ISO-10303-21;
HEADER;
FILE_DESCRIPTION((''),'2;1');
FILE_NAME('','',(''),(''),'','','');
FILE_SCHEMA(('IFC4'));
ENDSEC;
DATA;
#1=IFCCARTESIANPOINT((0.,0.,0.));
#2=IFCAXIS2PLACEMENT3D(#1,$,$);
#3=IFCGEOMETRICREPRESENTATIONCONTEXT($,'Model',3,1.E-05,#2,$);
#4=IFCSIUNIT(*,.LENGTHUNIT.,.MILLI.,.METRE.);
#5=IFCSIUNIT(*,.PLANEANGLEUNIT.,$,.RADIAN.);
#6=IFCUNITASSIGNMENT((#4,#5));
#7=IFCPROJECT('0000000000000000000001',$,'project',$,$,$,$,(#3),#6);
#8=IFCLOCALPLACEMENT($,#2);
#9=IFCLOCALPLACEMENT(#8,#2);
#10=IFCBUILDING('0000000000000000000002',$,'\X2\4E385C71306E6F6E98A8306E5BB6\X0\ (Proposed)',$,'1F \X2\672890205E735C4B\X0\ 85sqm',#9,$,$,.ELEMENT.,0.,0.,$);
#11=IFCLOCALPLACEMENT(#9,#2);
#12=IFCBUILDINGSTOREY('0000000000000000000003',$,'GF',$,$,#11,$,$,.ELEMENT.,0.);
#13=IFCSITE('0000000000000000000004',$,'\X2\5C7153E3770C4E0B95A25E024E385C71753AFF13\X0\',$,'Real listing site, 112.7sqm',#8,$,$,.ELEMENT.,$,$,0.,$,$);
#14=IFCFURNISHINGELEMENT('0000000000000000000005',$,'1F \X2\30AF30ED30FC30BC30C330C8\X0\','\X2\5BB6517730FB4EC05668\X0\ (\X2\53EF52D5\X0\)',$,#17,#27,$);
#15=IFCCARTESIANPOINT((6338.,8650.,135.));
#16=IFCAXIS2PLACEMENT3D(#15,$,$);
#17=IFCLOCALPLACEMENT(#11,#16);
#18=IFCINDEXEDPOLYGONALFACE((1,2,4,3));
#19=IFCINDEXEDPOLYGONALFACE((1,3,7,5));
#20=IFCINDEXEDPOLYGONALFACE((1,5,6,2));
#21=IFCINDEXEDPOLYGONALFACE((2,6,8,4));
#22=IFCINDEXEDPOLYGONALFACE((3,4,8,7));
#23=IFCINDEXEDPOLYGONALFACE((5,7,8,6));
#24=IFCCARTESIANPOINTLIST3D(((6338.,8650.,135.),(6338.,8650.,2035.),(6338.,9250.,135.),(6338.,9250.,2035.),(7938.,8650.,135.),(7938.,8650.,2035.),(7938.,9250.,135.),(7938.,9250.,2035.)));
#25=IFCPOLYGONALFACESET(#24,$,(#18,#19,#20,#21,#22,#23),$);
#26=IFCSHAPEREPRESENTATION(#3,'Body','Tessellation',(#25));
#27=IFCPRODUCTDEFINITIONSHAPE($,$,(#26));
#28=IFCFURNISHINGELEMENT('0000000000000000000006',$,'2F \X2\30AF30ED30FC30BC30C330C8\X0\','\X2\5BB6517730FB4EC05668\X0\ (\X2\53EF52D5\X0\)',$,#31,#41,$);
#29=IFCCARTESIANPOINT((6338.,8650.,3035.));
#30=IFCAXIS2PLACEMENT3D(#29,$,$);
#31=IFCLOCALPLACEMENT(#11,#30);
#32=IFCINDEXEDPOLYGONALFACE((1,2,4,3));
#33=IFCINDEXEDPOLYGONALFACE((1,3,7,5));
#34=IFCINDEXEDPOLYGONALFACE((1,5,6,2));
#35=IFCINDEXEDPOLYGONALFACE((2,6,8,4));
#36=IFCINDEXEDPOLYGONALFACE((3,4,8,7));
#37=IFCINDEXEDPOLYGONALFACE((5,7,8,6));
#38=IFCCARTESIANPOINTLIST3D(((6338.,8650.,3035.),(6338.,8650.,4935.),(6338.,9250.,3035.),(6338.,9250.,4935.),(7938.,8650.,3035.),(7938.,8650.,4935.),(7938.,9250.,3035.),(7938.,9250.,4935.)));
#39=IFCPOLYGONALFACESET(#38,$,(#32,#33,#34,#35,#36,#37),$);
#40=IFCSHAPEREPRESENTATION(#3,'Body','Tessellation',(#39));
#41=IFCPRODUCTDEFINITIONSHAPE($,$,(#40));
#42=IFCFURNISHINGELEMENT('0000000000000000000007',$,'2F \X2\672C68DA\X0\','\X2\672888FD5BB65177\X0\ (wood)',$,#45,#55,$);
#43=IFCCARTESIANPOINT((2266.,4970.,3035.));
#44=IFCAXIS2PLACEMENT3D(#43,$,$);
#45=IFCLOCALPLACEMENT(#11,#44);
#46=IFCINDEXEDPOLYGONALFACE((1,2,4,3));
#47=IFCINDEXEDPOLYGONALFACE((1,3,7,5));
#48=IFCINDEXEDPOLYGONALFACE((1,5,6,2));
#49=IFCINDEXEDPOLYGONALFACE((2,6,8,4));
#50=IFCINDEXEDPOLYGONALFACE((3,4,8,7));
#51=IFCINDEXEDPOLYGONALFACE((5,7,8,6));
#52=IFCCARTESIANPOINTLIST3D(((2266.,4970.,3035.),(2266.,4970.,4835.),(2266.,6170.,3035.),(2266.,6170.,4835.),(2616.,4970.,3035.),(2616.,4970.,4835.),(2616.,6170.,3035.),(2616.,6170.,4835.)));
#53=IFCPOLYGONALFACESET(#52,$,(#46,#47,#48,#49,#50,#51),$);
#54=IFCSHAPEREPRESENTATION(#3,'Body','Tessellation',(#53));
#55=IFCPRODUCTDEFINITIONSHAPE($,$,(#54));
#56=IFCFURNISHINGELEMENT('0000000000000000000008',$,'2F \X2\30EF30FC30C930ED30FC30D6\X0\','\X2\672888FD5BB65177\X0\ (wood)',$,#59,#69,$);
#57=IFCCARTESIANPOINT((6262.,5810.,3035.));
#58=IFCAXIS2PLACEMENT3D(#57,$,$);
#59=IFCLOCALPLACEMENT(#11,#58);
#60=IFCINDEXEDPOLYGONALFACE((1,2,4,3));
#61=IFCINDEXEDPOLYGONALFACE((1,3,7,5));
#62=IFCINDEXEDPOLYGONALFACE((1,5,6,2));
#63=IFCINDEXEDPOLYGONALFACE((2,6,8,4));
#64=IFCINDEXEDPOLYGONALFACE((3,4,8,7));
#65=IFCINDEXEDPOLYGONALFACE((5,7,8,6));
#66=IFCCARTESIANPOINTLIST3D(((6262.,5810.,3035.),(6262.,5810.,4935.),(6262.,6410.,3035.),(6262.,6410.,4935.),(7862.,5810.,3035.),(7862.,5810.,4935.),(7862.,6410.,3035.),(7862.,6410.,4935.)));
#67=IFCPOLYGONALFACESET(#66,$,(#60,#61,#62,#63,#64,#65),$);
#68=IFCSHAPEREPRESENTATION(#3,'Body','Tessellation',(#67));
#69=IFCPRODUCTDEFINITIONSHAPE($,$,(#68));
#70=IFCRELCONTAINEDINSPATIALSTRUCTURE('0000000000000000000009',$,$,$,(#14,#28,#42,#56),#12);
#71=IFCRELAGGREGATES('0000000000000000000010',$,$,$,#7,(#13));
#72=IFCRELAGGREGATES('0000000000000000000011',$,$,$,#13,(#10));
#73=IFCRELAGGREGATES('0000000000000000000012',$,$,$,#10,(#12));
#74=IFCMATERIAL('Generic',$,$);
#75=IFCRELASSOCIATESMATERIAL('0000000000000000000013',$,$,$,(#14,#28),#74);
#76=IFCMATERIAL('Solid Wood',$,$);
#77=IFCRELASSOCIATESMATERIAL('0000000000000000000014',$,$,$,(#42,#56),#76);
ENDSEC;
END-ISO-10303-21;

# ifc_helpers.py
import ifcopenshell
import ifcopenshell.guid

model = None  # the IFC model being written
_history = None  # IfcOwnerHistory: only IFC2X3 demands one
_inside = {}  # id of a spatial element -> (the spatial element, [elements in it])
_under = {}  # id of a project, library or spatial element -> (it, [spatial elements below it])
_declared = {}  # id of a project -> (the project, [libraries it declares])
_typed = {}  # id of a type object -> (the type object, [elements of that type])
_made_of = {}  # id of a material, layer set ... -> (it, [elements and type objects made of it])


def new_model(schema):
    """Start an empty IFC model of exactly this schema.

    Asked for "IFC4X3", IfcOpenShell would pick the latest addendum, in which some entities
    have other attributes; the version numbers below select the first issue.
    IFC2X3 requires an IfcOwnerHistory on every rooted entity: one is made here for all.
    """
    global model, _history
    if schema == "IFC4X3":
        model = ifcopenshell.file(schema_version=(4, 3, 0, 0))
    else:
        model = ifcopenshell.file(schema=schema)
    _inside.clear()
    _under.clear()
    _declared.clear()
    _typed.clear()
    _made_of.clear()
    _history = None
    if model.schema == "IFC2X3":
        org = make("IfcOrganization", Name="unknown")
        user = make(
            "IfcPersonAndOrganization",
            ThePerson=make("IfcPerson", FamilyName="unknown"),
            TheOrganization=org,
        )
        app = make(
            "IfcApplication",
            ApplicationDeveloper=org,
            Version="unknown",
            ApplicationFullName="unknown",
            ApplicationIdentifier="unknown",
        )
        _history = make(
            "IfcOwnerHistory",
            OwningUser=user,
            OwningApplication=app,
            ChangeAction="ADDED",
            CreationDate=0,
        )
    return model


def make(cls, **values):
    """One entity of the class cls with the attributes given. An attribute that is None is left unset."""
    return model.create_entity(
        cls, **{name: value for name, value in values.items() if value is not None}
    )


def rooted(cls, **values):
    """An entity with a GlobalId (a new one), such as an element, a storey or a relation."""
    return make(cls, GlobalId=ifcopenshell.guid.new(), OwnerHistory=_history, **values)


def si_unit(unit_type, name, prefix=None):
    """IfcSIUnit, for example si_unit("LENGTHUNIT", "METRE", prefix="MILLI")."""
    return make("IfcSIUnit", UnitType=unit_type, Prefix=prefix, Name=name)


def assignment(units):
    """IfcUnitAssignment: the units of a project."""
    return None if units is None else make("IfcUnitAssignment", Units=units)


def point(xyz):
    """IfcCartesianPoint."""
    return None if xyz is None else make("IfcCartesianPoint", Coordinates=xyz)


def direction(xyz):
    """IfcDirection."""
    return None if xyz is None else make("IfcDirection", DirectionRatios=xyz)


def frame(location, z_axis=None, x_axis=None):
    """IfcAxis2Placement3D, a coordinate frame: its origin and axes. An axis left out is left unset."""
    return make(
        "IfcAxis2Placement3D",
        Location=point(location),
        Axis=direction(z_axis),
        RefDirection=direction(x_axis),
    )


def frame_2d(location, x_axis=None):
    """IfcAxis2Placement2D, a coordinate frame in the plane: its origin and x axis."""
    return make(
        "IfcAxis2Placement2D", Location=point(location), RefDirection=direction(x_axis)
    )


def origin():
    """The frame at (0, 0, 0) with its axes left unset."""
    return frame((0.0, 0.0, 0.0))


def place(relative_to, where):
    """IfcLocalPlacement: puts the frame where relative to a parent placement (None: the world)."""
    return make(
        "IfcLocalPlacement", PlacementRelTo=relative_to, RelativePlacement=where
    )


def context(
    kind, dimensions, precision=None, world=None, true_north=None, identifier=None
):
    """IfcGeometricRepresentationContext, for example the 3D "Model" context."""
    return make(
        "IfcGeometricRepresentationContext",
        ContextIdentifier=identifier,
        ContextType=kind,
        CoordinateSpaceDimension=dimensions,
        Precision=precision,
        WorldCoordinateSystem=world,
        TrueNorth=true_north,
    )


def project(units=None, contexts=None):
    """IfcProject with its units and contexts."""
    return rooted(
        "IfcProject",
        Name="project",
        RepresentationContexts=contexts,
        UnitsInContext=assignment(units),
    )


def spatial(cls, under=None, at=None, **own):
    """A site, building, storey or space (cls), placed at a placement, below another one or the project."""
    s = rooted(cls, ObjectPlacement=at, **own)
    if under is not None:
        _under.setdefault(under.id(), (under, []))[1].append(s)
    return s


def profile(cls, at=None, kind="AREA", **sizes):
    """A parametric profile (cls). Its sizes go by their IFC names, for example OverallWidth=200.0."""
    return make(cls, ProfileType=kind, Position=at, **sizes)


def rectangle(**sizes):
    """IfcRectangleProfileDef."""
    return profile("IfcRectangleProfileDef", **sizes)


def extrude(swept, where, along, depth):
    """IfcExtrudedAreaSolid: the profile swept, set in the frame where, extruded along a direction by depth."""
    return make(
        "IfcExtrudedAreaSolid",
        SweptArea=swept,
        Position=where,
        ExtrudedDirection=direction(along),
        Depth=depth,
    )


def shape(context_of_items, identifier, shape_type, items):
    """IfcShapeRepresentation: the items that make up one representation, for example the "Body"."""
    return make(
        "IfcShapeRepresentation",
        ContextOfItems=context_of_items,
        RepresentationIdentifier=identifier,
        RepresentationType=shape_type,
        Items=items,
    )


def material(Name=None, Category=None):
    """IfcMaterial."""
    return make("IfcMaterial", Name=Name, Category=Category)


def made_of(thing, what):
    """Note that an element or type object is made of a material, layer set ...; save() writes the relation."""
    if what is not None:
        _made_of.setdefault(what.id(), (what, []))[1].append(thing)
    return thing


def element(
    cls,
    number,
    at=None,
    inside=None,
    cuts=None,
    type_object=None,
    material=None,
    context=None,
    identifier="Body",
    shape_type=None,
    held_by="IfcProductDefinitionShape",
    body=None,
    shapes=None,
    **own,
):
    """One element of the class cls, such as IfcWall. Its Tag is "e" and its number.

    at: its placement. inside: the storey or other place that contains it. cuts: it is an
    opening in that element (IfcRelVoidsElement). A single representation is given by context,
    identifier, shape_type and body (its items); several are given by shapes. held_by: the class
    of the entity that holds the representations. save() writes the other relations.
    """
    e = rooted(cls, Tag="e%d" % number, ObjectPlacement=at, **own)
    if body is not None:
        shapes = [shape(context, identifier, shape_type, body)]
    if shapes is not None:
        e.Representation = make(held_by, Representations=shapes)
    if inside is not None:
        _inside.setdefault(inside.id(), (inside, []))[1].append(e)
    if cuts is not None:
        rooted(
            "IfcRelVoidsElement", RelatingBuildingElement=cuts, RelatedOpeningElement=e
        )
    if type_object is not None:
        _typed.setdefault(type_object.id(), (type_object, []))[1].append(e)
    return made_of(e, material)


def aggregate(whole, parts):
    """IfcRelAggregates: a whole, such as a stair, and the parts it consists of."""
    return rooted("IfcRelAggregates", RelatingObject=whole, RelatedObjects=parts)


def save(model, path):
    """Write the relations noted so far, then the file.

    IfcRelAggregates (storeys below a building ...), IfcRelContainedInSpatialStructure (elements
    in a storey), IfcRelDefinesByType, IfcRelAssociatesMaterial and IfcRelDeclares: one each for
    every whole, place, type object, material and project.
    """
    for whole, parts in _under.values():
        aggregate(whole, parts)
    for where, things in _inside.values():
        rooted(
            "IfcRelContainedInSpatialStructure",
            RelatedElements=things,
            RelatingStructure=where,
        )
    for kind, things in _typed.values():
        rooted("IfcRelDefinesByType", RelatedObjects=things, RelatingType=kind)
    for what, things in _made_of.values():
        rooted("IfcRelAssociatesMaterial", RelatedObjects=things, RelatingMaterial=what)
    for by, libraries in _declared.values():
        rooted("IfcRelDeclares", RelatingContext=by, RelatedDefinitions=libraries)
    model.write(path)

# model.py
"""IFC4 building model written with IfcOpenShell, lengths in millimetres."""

from ifc_helpers import new_model, si_unit, frame, frame_2d, origin, place, context, project, spatial, rectangle, extrude, material, element, save


model = new_model("IFC4")

# Units and contexts
model_context = context("Model", 3, precision=1e-05, world=origin())
ifc_project = project(units=[si_unit("LENGTHUNIT", "METRE", prefix="MILLI"), si_unit("PLANEANGLEUNIT", "RADIAN")], contexts=[model_context])

# Site, building, storey
site_placement = place(None, origin())
site = spatial("IfcSite", under=ifc_project, at=site_placement, Name="山口県下関市丸山町３", ObjectType="Real listing site, 112.7sqm", CompositionType="ELEMENT", RefElevation=0.0)
building_placement = place(site_placement, origin())
building = spatial("IfcBuilding", under=site, at=building_placement, Name="丸山の潮風の家 (Proposed)", ObjectType="1F 木造平屋 85sqm", CompositionType="ELEMENT", ElevationOfRefHeight=0.0, ElevationOfTerrain=0.0)
storey_placement = place(building_placement, origin())
storey = spatial("IfcBuildingStorey", under=building, at=storey_placement, Name="GF", CompositionType="ELEMENT", Elevation=0.0)

# Shared definitions
ifc_material_1 = material(Name="Solid Wood")

# Shared definitions
ifc_material_2 = material(Name="Generic")

# Furnishing elements
furnishing_1_placement = place(storey_placement, frame((6338.0, 8650.0, 135.0)))
element("IfcFurnishingElement", 1, at=furnishing_1_placement, inside=storey, material=ifc_material_2, Name="1F クローゼット", Description="家具・什器 (可動)", context=model_context, shape_type="SweptSolid", body=[
    extrude(rectangle(XDim=1600.0, YDim=600.0, at=frame_2d((800.0, 300.0))), frame((6338.0, 8650.0, 135.0)), (0.0, 0.0, 1.0), 1900.0),
])
furnishing_2_placement = place(storey_placement, frame((6338.0, 8650.0, 3035.0)))
element("IfcFurnishingElement", 2, at=furnishing_2_placement, inside=storey, material=ifc_material_2, Name="2F クローゼット", Description="家具・什器 (可動)", context=model_context, shape_type="SweptSolid", body=[
    extrude(rectangle(XDim=1600.0, YDim=600.0, at=frame_2d((800.0, 300.0))), frame((6338.0, 8650.0, 3035.0)), (0.0, 0.0, 1.0), 1900.0),
])
furnishing_3_placement = place(storey_placement, frame((2266.0, 4970.0, 3035.0)))
element("IfcFurnishingElement", 3, at=furnishing_3_placement, inside=storey, material=ifc_material_1, Name="2F 本棚", Description="木製家具 (wood)", context=model_context, shape_type="SweptSolid", body=[
    extrude(rectangle(XDim=350.0, YDim=1200.0, at=frame_2d((175.0, 600.0))), frame((2266.0, 4970.0, 3035.0)), (0.0, 0.0, 1.0), 1800.0),
])
furnishing_4_placement = place(storey_placement, frame((6262.0, 5810.0, 3035.0)))
element("IfcFurnishingElement", 4, at=furnishing_4_placement, inside=storey, material=ifc_material_1, Name="2F ワードローブ", Description="木製家具 (wood)", context=model_context, shape_type="SweptSolid", body=[
    extrude(rectangle(XDim=1600.0, YDim=600.0, at=frame_2d((800.0, 300.0))), frame((6262.0, 5810.0, 3035.0)), (0.0, 0.0, 1.0), 1900.0),
])

save(model, "model.ifc")
